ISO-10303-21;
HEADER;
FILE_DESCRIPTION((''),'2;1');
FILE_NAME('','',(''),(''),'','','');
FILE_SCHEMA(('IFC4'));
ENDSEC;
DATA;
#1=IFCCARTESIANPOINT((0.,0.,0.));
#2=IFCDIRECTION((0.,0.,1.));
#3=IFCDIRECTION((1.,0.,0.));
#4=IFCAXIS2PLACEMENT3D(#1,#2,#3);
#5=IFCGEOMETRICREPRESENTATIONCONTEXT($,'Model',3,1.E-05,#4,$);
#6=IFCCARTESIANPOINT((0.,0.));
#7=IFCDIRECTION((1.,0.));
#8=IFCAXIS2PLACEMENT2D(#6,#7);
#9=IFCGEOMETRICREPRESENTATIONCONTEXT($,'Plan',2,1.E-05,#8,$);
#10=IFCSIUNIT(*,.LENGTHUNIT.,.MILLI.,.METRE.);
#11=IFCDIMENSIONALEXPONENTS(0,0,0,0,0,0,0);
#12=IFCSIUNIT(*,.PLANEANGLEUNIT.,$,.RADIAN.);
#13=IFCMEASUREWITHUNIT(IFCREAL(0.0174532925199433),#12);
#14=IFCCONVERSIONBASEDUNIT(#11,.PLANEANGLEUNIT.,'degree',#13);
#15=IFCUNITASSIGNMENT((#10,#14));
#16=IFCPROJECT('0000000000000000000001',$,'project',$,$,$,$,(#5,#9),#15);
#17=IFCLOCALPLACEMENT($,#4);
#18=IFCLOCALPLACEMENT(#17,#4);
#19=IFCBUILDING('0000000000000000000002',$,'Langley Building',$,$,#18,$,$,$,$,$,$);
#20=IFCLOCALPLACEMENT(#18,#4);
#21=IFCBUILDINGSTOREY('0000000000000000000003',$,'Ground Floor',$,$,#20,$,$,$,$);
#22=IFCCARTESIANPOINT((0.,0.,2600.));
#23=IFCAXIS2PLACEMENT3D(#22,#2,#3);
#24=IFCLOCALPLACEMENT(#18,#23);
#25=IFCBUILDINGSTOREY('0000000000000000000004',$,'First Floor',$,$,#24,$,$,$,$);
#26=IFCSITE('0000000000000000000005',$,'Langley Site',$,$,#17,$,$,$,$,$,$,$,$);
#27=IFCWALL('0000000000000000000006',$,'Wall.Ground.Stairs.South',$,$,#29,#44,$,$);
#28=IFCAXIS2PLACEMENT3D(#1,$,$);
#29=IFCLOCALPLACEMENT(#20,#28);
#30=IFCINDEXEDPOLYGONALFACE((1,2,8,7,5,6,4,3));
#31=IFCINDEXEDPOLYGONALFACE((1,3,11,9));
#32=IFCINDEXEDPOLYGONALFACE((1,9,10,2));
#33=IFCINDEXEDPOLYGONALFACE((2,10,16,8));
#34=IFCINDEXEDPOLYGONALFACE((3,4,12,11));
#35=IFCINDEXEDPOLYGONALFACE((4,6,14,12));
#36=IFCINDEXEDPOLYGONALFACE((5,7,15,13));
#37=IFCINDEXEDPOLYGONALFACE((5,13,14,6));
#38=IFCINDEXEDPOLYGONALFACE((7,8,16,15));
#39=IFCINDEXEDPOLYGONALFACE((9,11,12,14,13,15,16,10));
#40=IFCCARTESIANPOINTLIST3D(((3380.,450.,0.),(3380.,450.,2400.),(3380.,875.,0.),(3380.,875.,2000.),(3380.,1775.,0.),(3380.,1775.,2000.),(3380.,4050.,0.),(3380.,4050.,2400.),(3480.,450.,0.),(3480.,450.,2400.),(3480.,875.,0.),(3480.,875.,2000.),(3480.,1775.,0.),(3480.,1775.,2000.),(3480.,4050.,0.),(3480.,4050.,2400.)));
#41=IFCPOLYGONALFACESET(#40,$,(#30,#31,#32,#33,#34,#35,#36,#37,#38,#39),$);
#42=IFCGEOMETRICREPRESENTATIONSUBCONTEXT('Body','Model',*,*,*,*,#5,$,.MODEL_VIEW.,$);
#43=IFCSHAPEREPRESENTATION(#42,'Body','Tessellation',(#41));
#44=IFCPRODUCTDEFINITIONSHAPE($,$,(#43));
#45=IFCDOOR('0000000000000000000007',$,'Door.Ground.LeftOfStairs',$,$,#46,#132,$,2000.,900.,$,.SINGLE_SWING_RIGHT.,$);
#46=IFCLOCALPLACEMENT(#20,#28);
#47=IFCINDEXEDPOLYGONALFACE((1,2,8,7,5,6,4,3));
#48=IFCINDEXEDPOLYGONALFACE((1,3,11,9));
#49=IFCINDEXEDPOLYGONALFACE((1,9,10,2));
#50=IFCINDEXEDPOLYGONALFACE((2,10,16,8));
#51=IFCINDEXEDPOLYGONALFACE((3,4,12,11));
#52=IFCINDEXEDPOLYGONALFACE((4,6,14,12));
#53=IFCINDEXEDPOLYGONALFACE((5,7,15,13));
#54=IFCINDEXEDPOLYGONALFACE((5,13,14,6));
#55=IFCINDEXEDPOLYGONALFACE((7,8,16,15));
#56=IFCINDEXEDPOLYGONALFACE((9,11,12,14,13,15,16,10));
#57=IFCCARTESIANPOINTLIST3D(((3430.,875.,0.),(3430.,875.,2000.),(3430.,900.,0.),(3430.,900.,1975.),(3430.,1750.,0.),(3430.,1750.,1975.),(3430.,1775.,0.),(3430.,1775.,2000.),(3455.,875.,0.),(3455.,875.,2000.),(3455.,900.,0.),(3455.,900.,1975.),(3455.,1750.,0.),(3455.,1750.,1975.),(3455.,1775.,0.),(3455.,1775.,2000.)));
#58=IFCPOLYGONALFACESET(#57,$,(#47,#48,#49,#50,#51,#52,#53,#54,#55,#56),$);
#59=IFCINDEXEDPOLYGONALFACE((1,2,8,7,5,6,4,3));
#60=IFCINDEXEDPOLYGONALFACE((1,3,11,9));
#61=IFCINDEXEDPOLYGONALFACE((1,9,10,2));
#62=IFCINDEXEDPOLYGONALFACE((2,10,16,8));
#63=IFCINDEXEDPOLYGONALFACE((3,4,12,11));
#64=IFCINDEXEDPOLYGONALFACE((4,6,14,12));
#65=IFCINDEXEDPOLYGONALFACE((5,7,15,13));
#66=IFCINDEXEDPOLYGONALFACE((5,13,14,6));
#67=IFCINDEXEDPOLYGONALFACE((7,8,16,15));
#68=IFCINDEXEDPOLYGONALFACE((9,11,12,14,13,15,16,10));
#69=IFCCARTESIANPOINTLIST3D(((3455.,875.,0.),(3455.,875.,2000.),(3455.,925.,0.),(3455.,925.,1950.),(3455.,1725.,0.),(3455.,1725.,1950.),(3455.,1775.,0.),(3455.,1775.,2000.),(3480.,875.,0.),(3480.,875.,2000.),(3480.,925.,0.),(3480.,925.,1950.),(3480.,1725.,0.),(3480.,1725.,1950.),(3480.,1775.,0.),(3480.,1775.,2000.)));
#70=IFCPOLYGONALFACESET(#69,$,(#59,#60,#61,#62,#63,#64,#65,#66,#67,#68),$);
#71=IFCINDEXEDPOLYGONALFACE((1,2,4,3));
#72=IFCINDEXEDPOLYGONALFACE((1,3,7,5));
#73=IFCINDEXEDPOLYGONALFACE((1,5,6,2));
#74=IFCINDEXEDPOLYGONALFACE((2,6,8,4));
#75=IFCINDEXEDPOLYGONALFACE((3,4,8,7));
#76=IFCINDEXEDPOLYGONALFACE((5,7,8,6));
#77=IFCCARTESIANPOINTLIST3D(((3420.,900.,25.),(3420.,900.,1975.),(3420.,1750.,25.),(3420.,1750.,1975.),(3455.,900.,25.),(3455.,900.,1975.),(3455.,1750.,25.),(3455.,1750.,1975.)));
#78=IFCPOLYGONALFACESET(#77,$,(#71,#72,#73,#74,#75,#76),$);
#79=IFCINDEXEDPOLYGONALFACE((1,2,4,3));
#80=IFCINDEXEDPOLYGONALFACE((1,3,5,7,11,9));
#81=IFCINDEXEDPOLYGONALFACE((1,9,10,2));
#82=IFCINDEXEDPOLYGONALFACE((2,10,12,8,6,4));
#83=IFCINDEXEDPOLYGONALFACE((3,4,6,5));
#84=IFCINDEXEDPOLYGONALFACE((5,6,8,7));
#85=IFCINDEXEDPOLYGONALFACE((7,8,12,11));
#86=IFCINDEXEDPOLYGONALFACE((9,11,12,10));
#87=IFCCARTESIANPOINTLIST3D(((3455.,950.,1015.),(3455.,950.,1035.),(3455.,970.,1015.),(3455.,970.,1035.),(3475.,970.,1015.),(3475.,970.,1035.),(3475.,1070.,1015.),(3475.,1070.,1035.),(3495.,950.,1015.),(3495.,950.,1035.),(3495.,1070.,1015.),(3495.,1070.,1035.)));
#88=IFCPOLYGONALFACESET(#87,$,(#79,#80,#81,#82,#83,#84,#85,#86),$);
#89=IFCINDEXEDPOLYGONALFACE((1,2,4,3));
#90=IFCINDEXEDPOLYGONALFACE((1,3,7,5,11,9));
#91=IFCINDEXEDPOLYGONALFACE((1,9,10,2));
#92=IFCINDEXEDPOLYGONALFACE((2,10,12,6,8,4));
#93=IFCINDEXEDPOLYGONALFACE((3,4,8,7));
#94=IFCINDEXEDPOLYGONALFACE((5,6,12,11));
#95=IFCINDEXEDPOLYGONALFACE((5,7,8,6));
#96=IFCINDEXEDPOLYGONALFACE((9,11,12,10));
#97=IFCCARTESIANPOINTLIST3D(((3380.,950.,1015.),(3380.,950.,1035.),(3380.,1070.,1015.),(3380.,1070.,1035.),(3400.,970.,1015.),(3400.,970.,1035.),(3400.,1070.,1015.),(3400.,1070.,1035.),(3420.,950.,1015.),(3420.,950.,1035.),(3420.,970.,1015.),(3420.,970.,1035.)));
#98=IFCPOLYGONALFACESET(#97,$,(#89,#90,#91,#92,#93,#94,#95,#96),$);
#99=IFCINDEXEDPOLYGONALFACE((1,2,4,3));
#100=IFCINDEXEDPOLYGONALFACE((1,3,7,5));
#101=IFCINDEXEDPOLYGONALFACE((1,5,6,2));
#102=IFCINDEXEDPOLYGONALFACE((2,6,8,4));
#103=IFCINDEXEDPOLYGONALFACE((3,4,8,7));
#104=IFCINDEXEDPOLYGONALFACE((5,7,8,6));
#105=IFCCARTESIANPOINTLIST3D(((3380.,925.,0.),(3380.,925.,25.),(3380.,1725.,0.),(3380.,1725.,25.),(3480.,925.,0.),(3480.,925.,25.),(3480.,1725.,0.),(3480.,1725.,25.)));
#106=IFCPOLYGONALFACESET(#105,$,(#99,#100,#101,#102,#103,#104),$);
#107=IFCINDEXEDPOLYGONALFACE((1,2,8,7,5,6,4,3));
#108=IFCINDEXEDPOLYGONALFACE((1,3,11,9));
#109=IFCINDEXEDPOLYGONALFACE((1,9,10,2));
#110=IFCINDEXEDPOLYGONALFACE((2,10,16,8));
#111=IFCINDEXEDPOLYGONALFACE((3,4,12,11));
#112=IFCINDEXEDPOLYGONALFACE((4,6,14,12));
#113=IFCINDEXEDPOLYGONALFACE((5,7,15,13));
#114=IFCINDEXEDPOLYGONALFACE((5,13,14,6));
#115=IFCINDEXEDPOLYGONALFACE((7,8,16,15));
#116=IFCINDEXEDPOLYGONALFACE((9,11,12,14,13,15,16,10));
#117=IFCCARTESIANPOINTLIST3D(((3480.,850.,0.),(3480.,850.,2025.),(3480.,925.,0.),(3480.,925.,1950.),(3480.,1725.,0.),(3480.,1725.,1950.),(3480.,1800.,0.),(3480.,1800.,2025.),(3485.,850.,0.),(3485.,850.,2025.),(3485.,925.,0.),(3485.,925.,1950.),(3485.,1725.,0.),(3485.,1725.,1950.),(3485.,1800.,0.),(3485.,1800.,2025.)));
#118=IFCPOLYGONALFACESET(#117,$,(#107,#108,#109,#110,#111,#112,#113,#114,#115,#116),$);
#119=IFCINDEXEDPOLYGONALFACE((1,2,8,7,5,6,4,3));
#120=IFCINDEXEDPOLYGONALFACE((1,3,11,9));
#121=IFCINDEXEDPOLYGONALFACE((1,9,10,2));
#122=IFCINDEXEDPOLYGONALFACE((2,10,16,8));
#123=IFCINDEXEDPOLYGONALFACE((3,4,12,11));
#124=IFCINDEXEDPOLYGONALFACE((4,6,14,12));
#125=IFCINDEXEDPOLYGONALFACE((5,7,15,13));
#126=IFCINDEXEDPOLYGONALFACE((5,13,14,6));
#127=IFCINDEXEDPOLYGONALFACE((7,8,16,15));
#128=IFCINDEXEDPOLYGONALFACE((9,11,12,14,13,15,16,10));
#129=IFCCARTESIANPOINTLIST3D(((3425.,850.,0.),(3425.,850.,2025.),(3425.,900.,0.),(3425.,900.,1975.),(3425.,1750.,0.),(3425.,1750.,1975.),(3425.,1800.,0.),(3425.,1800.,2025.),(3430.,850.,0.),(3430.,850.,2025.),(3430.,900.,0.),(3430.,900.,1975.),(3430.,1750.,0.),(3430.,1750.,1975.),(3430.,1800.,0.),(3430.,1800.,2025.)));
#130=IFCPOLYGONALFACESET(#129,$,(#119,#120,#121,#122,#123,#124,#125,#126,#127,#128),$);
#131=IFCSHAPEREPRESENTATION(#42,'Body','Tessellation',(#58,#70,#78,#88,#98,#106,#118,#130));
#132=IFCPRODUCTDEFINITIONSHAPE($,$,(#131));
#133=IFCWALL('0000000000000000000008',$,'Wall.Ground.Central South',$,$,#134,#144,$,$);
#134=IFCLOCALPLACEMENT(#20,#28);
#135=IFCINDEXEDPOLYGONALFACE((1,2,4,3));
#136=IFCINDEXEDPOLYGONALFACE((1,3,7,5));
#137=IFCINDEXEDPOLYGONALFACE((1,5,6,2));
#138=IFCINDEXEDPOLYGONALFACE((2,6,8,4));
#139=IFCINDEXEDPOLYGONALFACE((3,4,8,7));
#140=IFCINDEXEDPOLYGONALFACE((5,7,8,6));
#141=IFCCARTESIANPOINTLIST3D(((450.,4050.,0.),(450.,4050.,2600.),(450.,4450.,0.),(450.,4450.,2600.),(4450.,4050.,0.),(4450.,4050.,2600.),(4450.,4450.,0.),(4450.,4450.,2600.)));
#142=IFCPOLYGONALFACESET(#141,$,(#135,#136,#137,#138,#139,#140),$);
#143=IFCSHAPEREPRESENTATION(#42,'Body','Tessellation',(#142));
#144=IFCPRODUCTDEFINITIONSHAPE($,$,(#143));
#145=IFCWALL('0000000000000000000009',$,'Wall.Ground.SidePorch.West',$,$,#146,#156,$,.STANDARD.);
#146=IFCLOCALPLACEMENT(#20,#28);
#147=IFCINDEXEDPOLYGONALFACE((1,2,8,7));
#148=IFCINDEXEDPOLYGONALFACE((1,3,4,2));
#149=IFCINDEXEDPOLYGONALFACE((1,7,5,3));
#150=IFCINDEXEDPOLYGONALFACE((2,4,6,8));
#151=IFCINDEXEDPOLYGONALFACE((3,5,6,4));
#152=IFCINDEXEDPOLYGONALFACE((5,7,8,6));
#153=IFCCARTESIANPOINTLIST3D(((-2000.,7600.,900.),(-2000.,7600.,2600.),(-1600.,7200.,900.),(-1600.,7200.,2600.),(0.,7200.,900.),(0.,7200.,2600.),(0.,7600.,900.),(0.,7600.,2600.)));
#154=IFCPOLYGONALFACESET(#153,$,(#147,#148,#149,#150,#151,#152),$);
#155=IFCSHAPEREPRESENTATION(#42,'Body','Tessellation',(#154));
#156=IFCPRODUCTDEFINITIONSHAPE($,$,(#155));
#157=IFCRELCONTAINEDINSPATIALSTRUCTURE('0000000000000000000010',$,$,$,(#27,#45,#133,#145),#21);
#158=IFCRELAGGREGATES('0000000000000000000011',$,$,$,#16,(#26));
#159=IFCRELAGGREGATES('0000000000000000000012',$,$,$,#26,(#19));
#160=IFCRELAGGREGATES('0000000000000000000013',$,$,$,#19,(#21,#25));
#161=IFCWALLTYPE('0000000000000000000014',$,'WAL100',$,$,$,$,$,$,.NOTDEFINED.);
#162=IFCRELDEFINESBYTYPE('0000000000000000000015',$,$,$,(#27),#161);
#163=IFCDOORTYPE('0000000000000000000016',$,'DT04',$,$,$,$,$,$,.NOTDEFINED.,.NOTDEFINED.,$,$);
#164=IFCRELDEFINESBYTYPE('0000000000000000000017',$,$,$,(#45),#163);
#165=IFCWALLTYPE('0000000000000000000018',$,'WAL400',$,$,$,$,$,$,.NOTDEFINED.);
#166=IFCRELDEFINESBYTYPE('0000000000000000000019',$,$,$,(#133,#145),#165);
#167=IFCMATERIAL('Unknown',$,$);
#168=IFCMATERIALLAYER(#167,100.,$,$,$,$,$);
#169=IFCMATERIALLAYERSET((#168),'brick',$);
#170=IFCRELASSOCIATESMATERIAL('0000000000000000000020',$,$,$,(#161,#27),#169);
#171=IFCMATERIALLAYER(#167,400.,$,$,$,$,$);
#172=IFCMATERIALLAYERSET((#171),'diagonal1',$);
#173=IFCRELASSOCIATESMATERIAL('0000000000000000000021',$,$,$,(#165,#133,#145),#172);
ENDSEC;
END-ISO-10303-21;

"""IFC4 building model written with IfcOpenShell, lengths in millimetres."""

from ifc_helpers import new_model, entity, si_unit, converted_unit, frame, origin_with_axes, origin_2d_with_axis, place, context, subcontext, project, spatial, line, indexed_curve, outline, extrude, shape, source, transform, mapped, material, layer, layer_set, layer_usage, type_object, type_shapes, element, fill, save


model = new_model("IFC4")

# Units and contexts
model_context = context("Model", 3, precision=1e-05, world=origin_with_axes())
plan_context = context("Plan", 2, precision=1e-05, world=origin_2d_with_axis())
body_context_1 = subcontext(model_context, "Body", "Model", "MODEL_VIEW")
body_context_2 = subcontext(plan_context, "Body", "Plan", "PLAN_VIEW")
ifc_project = project(units=[si_unit("LENGTHUNIT", "METRE", prefix="MILLI"), converted_unit("PLANEANGLEUNIT", "degree", entity("IfcReal", 0.0174532925199433), si_unit("PLANEANGLEUNIT", "RADIAN"), dimensions=[0, 0, 0, 0, 0, 0, 0])], contexts=[model_context, plan_context])

# Site, building, storey
site_placement = place(None, origin_with_axes())
site = spatial("IfcSite", under=ifc_project, at=site_placement, Name="Langley Site")
building_placement = place(site_placement, origin_with_axes())
building = spatial("IfcBuilding", under=site, at=building_placement, Name="Langley Building")
storey_1_placement = place(building_placement, origin_with_axes())
storey_1 = spatial("IfcBuildingStorey", under=building, at=storey_1_placement, Name="Ground Floor")

# Shared definitions
ifc_material = material(Name="Unknown")

# Wall, opening
ifc_layer_1 = layer(ifc_material, 100.0)
ifc_layer_set_1 = layer_set([ifc_layer_1], Name="brick")
ifc_layer_usage_1 = layer_usage(ifc_layer_set_1, "AXIS2", "POSITIVE", 0.0)
wall_type_1 = type_object("IfcWallType", Name="WAL100", PredefinedType="NOTDEFINED", material=ifc_layer_set_1)
wall_1_placement = place(storey_1_placement, frame((3480.0, 450.0, 0.0), z_axis=(0.0, 0.0, 1.0), x_axis=(0.0, 1.0, 0.0)))
wall_1 = element("IfcWall", 1, at=wall_1_placement, inside=storey_1, type_object=wall_type_1, material=ifc_layer_usage_1, Name="Wall.Ground.Stairs.South", context=body_context_1, shape_type="SweptSolid", body=[
    extrude(outline(indexed_curve([(0.0, 0.0), (0.0, 100.0), (3600.0, 100.0), (3600.0, 0.0)], segments=[line(1, 2, 3, 4, 1)])), origin_with_axes(), (0.0, 0.0, 1.0), 2400.0),
])
shared_shape_1 = source(origin_with_axes(), body_context_1, "Body", "SweptSolid", [
    extrude(outline(indexed_curve([(0.0, 0.0), (900.0, 0.0), (900.0, 2000.0), (0.0, 2000.0)], segments=[line(1, 2, 3, 4, 1)])), frame((0.0, -600.0, 0.0), z_axis=(0.0, -1.0, 0.0), x_axis=(1.0, 0.0, 0.0)), (0.0, 0.0, -1.0), 1200.0),
])
opening_1_placement = place(wall_1_placement, frame((1325.0, 85.0, 0.0), z_axis=(0.0, 0.0, 1.0), x_axis=(-1.0, 0.0, 0.0)))
opening_1 = element("IfcOpeningElement", 2, at=opening_1_placement, cuts=wall_1, PredefinedType="OPENING", context=body_context_1, shape_type="MappedRepresentation", body=[
    mapped(shared_shape_1, transform((0.0, 0.0, 0.0), x_axis=(1.0, 0.0, 0.0), y_axis=(0.0, 1.0, 0.0), z_axis=(0.0, 0.0, 1.0), scale=1.0)),
])

# Shared definitions
storey_2_placement = place(building_placement, frame((0.0, 0.0, 2600.0), z_axis=(0.0, 0.0, 1.0), x_axis=(1.0, 0.0, 0.0)))
storey_2 = spatial("IfcBuildingStorey", under=building, at=storey_2_placement, Name="First Floor")

# Opening
shared_shape_2 = source(origin_with_axes(), body_context_1, "Body", "SweptSolid", [
    extrude(outline(indexed_curve([(0.0, 0.0), (900.0, 0.0), (900.0, 2000.0), (0.0, 2000.0)], segments=[line(1, 2, 3, 4, 1)])), frame((0.0, -600.0, 0.0), z_axis=(0.0, -1.0, 0.0), x_axis=(1.0, 0.0, 0.0)), (0.0, 0.0, -1.0), 1200.0),
])
opening_2_placement = place(wall_1_placement, frame((2675.0, 0.0, 2600.0), z_axis=(0.0, 0.0, 1.0), x_axis=(1.0, 0.0, 0.0)))
element("IfcOpeningElement", 3, at=opening_2_placement, inside=storey_2, cuts=wall_1, PredefinedType="OPENING", context=body_context_1, shape_type="MappedRepresentation", body=[
    mapped(shared_shape_2, transform((0.0, 0.0, 0.0), x_axis=(1.0, 0.0, 0.0), y_axis=(0.0, 1.0, 0.0), z_axis=(0.0, 0.0, 1.0), scale=1.0)),
])

# Door
door_type_1 = type_object("IfcDoorType", Name="DT04", OperationType="NOTDEFINED", PredefinedType="NOTDEFINED")
shared_shape_3 = source(origin_with_axes(), body_context_1, "Body", "SweptSolid", [
    extrude(outline(indexed_curve([(0.0, 0.0), (0.0, 2000.0), (900.0, 2000.0), (900.0, 0.0), (875.0, 0.0), (875.0, 1975.0), (25.0, 1975.0), (25.0, 0.0)], segments=[line(1, 2, 3, 4, 5, 6, 7, 8, 1)])), frame((0.0, 25.0, 0.0), z_axis=(0.0, -1.0, 0.0), x_axis=(1.0, 0.0, 0.0)), (0.0, 0.0, -1.0), 25.0),
    extrude(outline(indexed_curve([(0.0, 0.0), (0.0, 2000.0), (900.0, 2000.0), (900.0, 0.0), (850.0, 0.0), (850.0, 1950.0), (50.0, 1950.0), (50.0, 0.0)], segments=[line(1, 2, 3, 4, 5, 6, 7, 8, 1)])), frame((0.0, 0.0, 0.0), z_axis=(0.0, -1.0, 0.0), x_axis=(1.0, 0.0, 0.0)), (0.0, 0.0, -1.0), 25.0),
    extrude(outline(indexed_curve([(0.0, 0.0), (850.0, 0.0), (850.0, 35.0), (0.0, 35.0)], segments=[line(1, 2, 3, 4, 1)])), frame((25.0, 25.0, 25.0), z_axis=(0.0, 0.0, 1.0), x_axis=(1.0, 0.0, 0.0)), (0.0, 0.0, 1.0), 1950.0),
    extrude(outline(indexed_curve([(0.0, 0.0), (0.0, -40.0), (120.0, -40.0), (120.0, -20.0), (20.0, -20.0), (20.0, 0.0)], segments=[line(1, 2, 3, 4, 5, 6, 1)])), frame((75.0, 25.0, 1015.0), z_axis=(0.0, 0.0, 1.0), x_axis=(1.0, 0.0, 0.0)), (0.0, 0.0, 1.0), 20.0),
    extrude(outline(indexed_curve([(0.0, 0.0), (0.0, 40.0), (120.0, 40.0), (120.0, 20.0), (20.0, 20.0), (20.0, 0.0)], segments=[line(1, 2, 3, 4, 5, 6, 1)])), frame((75.0, 60.0, 1015.0), z_axis=(0.0, 0.0, 1.0), x_axis=(1.0, 0.0, 0.0)), (0.0, 0.0, 1.0), 20.0),
    extrude(outline(indexed_curve([(0.0, 0.0), (800.0, 0.0), (800.0, 100.0), (0.0, 100.0)], segments=[line(1, 2, 3, 4, 1)])), frame((50.0, 0.0, 0.0), z_axis=(0.0, 0.0, 1.0), x_axis=(1.0, 0.0, 0.0)), (0.0, 0.0, 1.0), 25.0),
    extrude(outline(indexed_curve([(0.0, 0.0), (0.0, 2025.0), (950.0, 2025.0), (950.0, 0.0), (875.0, 0.0), (875.0, 1950.0), (75.0, 1950.0), (75.0, 0.0)], segments=[line(1, 2, 3, 4, 5, 6, 7, 8, 1)])), frame((-25.0, -5.0, 0.0), z_axis=(0.0, -1.0, 0.0), x_axis=(1.0, 0.0, 0.0)), (0.0, 0.0, -1.0), 5.0),
    extrude(outline(indexed_curve([(0.0, 0.0), (0.0, 2025.0), (950.0, 2025.0), (950.0, 0.0), (900.0, 0.0), (900.0, 1975.0), (50.0, 1975.0), (50.0, 0.0)], segments=[line(1, 2, 3, 4, 5, 6, 7, 8, 1)])), frame((-25.0, 50.0, 0.0), z_axis=(0.0, -1.0, 0.0), x_axis=(1.0, 0.0, 0.0)), (0.0, 0.0, -1.0), 5.0),
])
shared_shape_4 = source(origin_with_axes(), body_context_2, "Body", "Curve2D", [
    entity("IfcIndexedPolyCurve", entity("IfcCartesianPointList2D", [[0.0, 0.0], [0.0, 50.0], [25.0, 50.0], [25.0, 25.0], [50.0, 25.0], [50.0, 0.0]]), [entity("IfcLineIndex", [1, 2, 3, 4, 5, 6, 1])]),
    entity("IfcIndexedPolyCurve", entity("IfcCartesianPointList2D", [[900.0, 0.0], [900.0, 50.0], [875.0, 50.0], [875.0, 25.0], [850.0, 25.0], [850.0, 0.0]]), [entity("IfcLineIndex", [1, 2, 3, 4, 5, 6, 1])]),
    entity("IfcTrimmedCurve", entity("IfcEllipse", entity("IfcAxis2Placement2D", entity("IfcCartesianPoint", [840.0, 50.0]), entity("IfcDirection", [1.0, 0.0])), 815.0, 850.0), [entity("IfcCartesianPoint", [840.0, 900.0])], [entity("IfcCartesianPoint", [25.0, 50.0])], True, "CARTESIAN"),
    entity("IfcIndexedPolyCurve", entity("IfcCartesianPointList2D", [[875.0, 50.0], [840.0, 50.0], [840.0, 900.0], [875.0, 900.0]]), [entity("IfcLineIndex", [1, 2, 3, 4, 1])]),
])
type_shapes(door_type_1, [shared_shape_3, shared_shape_4])
door_1_placement = place(opening_1_placement, frame((900.0, 85.0, 0.0), z_axis=(0.0, 0.0, 1.0), x_axis=(-1.0, 0.0, 0.0)))
door_1 = element("IfcDoor", 4, at=door_1_placement, inside=storey_1, type_object=door_type_1, Name="Door.Ground.LeftOfStairs", OperationType="SINGLE_SWING_RIGHT", OverallHeight=2000.0, OverallWidth=900.0, shapes=[
    shape(body_context_1, "Body", "MappedRepresentation", [mapped(shared_shape_3, transform((0.0, 0.0, 0.0), x_axis=(1.0, 0.0, 0.0), y_axis=(0.0, 1.0, 0.0), z_axis=(0.0, 0.0, 1.0), scale=1.0))]),
    shape(body_context_2, "Body", "MappedRepresentation", [mapped(shared_shape_4, transform((0.0, 0.0, 0.0), x_axis=(1.0, 0.0, 0.0), y_axis=(0.0, 1.0, 0.0), z_axis=(0.0, 0.0, 1.0), scale=1.0))]),
])
fill(opening_1, door_1)

# Walls
ifc_layer_2 = layer(ifc_material, 400.0)
ifc_layer_set_2 = layer_set([ifc_layer_2], Name="diagonal1")
ifc_layer_usage_2 = layer_usage(ifc_layer_set_2, "AXIS2", "POSITIVE", 0.0)
wall_type_2 = type_object("IfcWallType", Name="WAL400", PredefinedType="NOTDEFINED", material=ifc_layer_set_2)
wall_2_placement = place(storey_1_placement, frame((450.0, 4050.0, 0.0), z_axis=(0.0, 0.0, 1.0), x_axis=(1.0, 0.0, 0.0)))
element("IfcWall", 5, at=wall_2_placement, inside=storey_1, type_object=wall_type_2, material=ifc_layer_usage_2, Name="Wall.Ground.Central South", context=body_context_1, shape_type="SweptSolid", body=[
    extrude(outline(indexed_curve([(0.0, 0.0), (0.0, 400.0), (4000.0, 400.0), (4000.0, 0.0)], segments=[line(1, 2, 3, 4, 1)])), origin_with_axes(), (0.0, 0.0, 1.0), 2600.0),
])
ifc_layer_usage_3 = layer_usage(ifc_layer_set_2, "AXIS2", "POSITIVE", 0.0)
wall_3_placement = place(storey_1_placement, frame((0.0, 7600.0, 900.0), z_axis=(0.0, 0.0, 1.0), x_axis=(-1.0, 0.0, 0.0)))
element("IfcWall", 6, at=wall_3_placement, inside=storey_1, type_object=wall_type_2, material=ifc_layer_usage_3, Name="Wall.Ground.SidePorch.West", PredefinedType="STANDARD", context=body_context_1, shape_type="SweptSolid", body=[
    extrude(outline(indexed_curve([(0.0, 0.0), (0.0, 400.0), (1600.0, 400.0), (2000.0, 0.0)], segments=[line(1, 2, 3, 4, 1)])), origin_with_axes(), (0.0, 0.0, 1.0), 1700.0),
])

save(model, "model.ifc")
